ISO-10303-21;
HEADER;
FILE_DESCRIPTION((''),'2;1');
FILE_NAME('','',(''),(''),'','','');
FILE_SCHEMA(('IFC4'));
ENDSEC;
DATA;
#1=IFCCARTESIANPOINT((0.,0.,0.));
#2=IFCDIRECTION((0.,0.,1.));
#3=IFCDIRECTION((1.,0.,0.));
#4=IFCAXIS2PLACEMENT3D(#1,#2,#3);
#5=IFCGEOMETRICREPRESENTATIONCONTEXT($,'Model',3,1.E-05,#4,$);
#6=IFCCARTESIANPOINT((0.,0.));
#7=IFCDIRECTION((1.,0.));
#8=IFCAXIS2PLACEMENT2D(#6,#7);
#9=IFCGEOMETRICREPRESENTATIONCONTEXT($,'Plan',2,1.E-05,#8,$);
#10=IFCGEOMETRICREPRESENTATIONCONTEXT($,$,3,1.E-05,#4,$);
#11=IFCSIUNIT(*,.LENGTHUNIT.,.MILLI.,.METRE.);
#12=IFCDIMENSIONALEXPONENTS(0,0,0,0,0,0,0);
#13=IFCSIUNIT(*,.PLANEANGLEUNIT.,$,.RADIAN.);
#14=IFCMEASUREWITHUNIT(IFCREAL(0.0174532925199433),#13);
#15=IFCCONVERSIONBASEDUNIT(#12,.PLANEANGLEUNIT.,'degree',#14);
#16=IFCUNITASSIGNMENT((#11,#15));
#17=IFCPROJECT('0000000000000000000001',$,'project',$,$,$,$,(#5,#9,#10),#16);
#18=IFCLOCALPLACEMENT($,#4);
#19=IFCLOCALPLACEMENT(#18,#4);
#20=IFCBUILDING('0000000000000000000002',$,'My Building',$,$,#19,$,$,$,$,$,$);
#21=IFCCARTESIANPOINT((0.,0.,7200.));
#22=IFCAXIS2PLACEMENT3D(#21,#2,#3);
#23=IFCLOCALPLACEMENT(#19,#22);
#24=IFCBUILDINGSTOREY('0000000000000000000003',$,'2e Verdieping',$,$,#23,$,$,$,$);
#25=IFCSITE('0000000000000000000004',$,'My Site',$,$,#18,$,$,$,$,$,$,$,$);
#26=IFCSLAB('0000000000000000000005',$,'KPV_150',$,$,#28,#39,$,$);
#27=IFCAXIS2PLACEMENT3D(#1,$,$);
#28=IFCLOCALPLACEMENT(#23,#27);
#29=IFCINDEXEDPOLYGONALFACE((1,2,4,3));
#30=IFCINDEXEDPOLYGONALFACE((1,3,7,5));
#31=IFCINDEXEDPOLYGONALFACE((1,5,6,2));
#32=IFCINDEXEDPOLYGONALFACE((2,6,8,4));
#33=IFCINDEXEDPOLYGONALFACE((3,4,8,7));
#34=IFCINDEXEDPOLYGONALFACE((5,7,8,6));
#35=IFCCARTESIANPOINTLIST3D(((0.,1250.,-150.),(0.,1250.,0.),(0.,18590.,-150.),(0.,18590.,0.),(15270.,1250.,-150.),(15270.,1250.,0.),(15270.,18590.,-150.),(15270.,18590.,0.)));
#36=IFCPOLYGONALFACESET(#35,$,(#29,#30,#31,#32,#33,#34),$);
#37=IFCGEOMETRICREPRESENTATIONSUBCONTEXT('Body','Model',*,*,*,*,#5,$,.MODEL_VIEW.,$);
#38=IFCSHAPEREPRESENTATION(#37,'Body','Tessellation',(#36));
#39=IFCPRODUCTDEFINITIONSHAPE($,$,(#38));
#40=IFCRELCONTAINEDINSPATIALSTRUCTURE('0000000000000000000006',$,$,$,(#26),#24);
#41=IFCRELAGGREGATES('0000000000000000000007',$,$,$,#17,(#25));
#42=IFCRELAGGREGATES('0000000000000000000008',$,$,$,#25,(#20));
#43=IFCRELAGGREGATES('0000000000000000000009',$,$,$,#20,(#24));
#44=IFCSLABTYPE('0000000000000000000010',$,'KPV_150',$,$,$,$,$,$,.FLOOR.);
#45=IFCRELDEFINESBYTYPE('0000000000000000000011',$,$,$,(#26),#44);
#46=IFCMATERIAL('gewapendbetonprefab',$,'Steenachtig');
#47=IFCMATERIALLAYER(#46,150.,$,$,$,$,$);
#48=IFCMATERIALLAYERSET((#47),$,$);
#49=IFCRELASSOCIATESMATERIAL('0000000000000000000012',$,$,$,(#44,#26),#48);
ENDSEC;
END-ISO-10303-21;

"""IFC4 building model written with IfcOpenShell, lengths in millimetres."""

from ifc_helpers import new_model, entity, si_unit, converted_unit, frame, origin_with_axes, origin_2d_with_axis, place, context, subcontext, project, spatial, line, indexed_curve, outline, extrude, material, layer, layer_set, layer_usage, type_object, element, save


model = new_model("IFC4")

# Units and contexts
model_context = context("Model", 3, precision=1e-05, world=origin_with_axes())
plan_context = context("Plan", 2, precision=1e-05, world=origin_2d_with_axis())
context_of_model = context(None, 3, precision=1e-05, world=origin_with_axes())
body_context = subcontext(model_context, "Body", "Model", "MODEL_VIEW")
ifc_project = project(units=[si_unit("LENGTHUNIT", "METRE", prefix="MILLI"), converted_unit("PLANEANGLEUNIT", "degree", entity("IfcReal", 0.0174532925199433), si_unit("PLANEANGLEUNIT", "RADIAN"), dimensions=[0, 0, 0, 0, 0, 0, 0])], contexts=[model_context, plan_context, context_of_model])

# Site, building, storey
site_placement = place(None, origin_with_axes())
site = spatial("IfcSite", under=ifc_project, at=site_placement, Name="My Site")
building_placement = place(site_placement, origin_with_axes())
building = spatial("IfcBuilding", under=site, at=building_placement, Name="My Building")
storey_placement = place(building_placement, frame((0.0, 0.0, 7200.0), z_axis=(0.0, 0.0, 1.0), x_axis=(1.0, 0.0, 0.0)))
storey = spatial("IfcBuildingStorey", under=building, at=storey_placement, Name="2e Verdieping")

# Slab
ifc_material = material(Name="gewapendbetonprefab", Category="Steenachtig")
ifc_layer = layer(ifc_material, 150.0)
ifc_layer_set = layer_set([ifc_layer])
ifc_layer_usage = layer_usage(ifc_layer_set, "AXIS3", "POSITIVE", 0.0)
slab_type = type_object("IfcSlabType", Name="KPV_150", PredefinedType="FLOOR", material=ifc_layer_set)
slab_placement = place(storey_placement, frame((0.0, 18590.0, -150.0), z_axis=(0.0, 0.0, 1.0), x_axis=(1.0, 0.0, 0.0)))
element("IfcSlab", 1, at=slab_placement, inside=storey, type_object=slab_type, material=ifc_layer_usage, Name="KPV_150", context=body_context, shape_type="SweptSolid", body=[
    extrude(outline(indexed_curve([(0.0, 0.0), (0.0, -17340.0), (15270.0, -17340.0), (15270.0, 0.0)], segments=[line(3, 2), line(2, 1), line(1, 4), line(4, 3)], self_intersect=False)), None, (0.0, 0.0, 1.0), 150.0),
])

save(model, "model.ifc")
